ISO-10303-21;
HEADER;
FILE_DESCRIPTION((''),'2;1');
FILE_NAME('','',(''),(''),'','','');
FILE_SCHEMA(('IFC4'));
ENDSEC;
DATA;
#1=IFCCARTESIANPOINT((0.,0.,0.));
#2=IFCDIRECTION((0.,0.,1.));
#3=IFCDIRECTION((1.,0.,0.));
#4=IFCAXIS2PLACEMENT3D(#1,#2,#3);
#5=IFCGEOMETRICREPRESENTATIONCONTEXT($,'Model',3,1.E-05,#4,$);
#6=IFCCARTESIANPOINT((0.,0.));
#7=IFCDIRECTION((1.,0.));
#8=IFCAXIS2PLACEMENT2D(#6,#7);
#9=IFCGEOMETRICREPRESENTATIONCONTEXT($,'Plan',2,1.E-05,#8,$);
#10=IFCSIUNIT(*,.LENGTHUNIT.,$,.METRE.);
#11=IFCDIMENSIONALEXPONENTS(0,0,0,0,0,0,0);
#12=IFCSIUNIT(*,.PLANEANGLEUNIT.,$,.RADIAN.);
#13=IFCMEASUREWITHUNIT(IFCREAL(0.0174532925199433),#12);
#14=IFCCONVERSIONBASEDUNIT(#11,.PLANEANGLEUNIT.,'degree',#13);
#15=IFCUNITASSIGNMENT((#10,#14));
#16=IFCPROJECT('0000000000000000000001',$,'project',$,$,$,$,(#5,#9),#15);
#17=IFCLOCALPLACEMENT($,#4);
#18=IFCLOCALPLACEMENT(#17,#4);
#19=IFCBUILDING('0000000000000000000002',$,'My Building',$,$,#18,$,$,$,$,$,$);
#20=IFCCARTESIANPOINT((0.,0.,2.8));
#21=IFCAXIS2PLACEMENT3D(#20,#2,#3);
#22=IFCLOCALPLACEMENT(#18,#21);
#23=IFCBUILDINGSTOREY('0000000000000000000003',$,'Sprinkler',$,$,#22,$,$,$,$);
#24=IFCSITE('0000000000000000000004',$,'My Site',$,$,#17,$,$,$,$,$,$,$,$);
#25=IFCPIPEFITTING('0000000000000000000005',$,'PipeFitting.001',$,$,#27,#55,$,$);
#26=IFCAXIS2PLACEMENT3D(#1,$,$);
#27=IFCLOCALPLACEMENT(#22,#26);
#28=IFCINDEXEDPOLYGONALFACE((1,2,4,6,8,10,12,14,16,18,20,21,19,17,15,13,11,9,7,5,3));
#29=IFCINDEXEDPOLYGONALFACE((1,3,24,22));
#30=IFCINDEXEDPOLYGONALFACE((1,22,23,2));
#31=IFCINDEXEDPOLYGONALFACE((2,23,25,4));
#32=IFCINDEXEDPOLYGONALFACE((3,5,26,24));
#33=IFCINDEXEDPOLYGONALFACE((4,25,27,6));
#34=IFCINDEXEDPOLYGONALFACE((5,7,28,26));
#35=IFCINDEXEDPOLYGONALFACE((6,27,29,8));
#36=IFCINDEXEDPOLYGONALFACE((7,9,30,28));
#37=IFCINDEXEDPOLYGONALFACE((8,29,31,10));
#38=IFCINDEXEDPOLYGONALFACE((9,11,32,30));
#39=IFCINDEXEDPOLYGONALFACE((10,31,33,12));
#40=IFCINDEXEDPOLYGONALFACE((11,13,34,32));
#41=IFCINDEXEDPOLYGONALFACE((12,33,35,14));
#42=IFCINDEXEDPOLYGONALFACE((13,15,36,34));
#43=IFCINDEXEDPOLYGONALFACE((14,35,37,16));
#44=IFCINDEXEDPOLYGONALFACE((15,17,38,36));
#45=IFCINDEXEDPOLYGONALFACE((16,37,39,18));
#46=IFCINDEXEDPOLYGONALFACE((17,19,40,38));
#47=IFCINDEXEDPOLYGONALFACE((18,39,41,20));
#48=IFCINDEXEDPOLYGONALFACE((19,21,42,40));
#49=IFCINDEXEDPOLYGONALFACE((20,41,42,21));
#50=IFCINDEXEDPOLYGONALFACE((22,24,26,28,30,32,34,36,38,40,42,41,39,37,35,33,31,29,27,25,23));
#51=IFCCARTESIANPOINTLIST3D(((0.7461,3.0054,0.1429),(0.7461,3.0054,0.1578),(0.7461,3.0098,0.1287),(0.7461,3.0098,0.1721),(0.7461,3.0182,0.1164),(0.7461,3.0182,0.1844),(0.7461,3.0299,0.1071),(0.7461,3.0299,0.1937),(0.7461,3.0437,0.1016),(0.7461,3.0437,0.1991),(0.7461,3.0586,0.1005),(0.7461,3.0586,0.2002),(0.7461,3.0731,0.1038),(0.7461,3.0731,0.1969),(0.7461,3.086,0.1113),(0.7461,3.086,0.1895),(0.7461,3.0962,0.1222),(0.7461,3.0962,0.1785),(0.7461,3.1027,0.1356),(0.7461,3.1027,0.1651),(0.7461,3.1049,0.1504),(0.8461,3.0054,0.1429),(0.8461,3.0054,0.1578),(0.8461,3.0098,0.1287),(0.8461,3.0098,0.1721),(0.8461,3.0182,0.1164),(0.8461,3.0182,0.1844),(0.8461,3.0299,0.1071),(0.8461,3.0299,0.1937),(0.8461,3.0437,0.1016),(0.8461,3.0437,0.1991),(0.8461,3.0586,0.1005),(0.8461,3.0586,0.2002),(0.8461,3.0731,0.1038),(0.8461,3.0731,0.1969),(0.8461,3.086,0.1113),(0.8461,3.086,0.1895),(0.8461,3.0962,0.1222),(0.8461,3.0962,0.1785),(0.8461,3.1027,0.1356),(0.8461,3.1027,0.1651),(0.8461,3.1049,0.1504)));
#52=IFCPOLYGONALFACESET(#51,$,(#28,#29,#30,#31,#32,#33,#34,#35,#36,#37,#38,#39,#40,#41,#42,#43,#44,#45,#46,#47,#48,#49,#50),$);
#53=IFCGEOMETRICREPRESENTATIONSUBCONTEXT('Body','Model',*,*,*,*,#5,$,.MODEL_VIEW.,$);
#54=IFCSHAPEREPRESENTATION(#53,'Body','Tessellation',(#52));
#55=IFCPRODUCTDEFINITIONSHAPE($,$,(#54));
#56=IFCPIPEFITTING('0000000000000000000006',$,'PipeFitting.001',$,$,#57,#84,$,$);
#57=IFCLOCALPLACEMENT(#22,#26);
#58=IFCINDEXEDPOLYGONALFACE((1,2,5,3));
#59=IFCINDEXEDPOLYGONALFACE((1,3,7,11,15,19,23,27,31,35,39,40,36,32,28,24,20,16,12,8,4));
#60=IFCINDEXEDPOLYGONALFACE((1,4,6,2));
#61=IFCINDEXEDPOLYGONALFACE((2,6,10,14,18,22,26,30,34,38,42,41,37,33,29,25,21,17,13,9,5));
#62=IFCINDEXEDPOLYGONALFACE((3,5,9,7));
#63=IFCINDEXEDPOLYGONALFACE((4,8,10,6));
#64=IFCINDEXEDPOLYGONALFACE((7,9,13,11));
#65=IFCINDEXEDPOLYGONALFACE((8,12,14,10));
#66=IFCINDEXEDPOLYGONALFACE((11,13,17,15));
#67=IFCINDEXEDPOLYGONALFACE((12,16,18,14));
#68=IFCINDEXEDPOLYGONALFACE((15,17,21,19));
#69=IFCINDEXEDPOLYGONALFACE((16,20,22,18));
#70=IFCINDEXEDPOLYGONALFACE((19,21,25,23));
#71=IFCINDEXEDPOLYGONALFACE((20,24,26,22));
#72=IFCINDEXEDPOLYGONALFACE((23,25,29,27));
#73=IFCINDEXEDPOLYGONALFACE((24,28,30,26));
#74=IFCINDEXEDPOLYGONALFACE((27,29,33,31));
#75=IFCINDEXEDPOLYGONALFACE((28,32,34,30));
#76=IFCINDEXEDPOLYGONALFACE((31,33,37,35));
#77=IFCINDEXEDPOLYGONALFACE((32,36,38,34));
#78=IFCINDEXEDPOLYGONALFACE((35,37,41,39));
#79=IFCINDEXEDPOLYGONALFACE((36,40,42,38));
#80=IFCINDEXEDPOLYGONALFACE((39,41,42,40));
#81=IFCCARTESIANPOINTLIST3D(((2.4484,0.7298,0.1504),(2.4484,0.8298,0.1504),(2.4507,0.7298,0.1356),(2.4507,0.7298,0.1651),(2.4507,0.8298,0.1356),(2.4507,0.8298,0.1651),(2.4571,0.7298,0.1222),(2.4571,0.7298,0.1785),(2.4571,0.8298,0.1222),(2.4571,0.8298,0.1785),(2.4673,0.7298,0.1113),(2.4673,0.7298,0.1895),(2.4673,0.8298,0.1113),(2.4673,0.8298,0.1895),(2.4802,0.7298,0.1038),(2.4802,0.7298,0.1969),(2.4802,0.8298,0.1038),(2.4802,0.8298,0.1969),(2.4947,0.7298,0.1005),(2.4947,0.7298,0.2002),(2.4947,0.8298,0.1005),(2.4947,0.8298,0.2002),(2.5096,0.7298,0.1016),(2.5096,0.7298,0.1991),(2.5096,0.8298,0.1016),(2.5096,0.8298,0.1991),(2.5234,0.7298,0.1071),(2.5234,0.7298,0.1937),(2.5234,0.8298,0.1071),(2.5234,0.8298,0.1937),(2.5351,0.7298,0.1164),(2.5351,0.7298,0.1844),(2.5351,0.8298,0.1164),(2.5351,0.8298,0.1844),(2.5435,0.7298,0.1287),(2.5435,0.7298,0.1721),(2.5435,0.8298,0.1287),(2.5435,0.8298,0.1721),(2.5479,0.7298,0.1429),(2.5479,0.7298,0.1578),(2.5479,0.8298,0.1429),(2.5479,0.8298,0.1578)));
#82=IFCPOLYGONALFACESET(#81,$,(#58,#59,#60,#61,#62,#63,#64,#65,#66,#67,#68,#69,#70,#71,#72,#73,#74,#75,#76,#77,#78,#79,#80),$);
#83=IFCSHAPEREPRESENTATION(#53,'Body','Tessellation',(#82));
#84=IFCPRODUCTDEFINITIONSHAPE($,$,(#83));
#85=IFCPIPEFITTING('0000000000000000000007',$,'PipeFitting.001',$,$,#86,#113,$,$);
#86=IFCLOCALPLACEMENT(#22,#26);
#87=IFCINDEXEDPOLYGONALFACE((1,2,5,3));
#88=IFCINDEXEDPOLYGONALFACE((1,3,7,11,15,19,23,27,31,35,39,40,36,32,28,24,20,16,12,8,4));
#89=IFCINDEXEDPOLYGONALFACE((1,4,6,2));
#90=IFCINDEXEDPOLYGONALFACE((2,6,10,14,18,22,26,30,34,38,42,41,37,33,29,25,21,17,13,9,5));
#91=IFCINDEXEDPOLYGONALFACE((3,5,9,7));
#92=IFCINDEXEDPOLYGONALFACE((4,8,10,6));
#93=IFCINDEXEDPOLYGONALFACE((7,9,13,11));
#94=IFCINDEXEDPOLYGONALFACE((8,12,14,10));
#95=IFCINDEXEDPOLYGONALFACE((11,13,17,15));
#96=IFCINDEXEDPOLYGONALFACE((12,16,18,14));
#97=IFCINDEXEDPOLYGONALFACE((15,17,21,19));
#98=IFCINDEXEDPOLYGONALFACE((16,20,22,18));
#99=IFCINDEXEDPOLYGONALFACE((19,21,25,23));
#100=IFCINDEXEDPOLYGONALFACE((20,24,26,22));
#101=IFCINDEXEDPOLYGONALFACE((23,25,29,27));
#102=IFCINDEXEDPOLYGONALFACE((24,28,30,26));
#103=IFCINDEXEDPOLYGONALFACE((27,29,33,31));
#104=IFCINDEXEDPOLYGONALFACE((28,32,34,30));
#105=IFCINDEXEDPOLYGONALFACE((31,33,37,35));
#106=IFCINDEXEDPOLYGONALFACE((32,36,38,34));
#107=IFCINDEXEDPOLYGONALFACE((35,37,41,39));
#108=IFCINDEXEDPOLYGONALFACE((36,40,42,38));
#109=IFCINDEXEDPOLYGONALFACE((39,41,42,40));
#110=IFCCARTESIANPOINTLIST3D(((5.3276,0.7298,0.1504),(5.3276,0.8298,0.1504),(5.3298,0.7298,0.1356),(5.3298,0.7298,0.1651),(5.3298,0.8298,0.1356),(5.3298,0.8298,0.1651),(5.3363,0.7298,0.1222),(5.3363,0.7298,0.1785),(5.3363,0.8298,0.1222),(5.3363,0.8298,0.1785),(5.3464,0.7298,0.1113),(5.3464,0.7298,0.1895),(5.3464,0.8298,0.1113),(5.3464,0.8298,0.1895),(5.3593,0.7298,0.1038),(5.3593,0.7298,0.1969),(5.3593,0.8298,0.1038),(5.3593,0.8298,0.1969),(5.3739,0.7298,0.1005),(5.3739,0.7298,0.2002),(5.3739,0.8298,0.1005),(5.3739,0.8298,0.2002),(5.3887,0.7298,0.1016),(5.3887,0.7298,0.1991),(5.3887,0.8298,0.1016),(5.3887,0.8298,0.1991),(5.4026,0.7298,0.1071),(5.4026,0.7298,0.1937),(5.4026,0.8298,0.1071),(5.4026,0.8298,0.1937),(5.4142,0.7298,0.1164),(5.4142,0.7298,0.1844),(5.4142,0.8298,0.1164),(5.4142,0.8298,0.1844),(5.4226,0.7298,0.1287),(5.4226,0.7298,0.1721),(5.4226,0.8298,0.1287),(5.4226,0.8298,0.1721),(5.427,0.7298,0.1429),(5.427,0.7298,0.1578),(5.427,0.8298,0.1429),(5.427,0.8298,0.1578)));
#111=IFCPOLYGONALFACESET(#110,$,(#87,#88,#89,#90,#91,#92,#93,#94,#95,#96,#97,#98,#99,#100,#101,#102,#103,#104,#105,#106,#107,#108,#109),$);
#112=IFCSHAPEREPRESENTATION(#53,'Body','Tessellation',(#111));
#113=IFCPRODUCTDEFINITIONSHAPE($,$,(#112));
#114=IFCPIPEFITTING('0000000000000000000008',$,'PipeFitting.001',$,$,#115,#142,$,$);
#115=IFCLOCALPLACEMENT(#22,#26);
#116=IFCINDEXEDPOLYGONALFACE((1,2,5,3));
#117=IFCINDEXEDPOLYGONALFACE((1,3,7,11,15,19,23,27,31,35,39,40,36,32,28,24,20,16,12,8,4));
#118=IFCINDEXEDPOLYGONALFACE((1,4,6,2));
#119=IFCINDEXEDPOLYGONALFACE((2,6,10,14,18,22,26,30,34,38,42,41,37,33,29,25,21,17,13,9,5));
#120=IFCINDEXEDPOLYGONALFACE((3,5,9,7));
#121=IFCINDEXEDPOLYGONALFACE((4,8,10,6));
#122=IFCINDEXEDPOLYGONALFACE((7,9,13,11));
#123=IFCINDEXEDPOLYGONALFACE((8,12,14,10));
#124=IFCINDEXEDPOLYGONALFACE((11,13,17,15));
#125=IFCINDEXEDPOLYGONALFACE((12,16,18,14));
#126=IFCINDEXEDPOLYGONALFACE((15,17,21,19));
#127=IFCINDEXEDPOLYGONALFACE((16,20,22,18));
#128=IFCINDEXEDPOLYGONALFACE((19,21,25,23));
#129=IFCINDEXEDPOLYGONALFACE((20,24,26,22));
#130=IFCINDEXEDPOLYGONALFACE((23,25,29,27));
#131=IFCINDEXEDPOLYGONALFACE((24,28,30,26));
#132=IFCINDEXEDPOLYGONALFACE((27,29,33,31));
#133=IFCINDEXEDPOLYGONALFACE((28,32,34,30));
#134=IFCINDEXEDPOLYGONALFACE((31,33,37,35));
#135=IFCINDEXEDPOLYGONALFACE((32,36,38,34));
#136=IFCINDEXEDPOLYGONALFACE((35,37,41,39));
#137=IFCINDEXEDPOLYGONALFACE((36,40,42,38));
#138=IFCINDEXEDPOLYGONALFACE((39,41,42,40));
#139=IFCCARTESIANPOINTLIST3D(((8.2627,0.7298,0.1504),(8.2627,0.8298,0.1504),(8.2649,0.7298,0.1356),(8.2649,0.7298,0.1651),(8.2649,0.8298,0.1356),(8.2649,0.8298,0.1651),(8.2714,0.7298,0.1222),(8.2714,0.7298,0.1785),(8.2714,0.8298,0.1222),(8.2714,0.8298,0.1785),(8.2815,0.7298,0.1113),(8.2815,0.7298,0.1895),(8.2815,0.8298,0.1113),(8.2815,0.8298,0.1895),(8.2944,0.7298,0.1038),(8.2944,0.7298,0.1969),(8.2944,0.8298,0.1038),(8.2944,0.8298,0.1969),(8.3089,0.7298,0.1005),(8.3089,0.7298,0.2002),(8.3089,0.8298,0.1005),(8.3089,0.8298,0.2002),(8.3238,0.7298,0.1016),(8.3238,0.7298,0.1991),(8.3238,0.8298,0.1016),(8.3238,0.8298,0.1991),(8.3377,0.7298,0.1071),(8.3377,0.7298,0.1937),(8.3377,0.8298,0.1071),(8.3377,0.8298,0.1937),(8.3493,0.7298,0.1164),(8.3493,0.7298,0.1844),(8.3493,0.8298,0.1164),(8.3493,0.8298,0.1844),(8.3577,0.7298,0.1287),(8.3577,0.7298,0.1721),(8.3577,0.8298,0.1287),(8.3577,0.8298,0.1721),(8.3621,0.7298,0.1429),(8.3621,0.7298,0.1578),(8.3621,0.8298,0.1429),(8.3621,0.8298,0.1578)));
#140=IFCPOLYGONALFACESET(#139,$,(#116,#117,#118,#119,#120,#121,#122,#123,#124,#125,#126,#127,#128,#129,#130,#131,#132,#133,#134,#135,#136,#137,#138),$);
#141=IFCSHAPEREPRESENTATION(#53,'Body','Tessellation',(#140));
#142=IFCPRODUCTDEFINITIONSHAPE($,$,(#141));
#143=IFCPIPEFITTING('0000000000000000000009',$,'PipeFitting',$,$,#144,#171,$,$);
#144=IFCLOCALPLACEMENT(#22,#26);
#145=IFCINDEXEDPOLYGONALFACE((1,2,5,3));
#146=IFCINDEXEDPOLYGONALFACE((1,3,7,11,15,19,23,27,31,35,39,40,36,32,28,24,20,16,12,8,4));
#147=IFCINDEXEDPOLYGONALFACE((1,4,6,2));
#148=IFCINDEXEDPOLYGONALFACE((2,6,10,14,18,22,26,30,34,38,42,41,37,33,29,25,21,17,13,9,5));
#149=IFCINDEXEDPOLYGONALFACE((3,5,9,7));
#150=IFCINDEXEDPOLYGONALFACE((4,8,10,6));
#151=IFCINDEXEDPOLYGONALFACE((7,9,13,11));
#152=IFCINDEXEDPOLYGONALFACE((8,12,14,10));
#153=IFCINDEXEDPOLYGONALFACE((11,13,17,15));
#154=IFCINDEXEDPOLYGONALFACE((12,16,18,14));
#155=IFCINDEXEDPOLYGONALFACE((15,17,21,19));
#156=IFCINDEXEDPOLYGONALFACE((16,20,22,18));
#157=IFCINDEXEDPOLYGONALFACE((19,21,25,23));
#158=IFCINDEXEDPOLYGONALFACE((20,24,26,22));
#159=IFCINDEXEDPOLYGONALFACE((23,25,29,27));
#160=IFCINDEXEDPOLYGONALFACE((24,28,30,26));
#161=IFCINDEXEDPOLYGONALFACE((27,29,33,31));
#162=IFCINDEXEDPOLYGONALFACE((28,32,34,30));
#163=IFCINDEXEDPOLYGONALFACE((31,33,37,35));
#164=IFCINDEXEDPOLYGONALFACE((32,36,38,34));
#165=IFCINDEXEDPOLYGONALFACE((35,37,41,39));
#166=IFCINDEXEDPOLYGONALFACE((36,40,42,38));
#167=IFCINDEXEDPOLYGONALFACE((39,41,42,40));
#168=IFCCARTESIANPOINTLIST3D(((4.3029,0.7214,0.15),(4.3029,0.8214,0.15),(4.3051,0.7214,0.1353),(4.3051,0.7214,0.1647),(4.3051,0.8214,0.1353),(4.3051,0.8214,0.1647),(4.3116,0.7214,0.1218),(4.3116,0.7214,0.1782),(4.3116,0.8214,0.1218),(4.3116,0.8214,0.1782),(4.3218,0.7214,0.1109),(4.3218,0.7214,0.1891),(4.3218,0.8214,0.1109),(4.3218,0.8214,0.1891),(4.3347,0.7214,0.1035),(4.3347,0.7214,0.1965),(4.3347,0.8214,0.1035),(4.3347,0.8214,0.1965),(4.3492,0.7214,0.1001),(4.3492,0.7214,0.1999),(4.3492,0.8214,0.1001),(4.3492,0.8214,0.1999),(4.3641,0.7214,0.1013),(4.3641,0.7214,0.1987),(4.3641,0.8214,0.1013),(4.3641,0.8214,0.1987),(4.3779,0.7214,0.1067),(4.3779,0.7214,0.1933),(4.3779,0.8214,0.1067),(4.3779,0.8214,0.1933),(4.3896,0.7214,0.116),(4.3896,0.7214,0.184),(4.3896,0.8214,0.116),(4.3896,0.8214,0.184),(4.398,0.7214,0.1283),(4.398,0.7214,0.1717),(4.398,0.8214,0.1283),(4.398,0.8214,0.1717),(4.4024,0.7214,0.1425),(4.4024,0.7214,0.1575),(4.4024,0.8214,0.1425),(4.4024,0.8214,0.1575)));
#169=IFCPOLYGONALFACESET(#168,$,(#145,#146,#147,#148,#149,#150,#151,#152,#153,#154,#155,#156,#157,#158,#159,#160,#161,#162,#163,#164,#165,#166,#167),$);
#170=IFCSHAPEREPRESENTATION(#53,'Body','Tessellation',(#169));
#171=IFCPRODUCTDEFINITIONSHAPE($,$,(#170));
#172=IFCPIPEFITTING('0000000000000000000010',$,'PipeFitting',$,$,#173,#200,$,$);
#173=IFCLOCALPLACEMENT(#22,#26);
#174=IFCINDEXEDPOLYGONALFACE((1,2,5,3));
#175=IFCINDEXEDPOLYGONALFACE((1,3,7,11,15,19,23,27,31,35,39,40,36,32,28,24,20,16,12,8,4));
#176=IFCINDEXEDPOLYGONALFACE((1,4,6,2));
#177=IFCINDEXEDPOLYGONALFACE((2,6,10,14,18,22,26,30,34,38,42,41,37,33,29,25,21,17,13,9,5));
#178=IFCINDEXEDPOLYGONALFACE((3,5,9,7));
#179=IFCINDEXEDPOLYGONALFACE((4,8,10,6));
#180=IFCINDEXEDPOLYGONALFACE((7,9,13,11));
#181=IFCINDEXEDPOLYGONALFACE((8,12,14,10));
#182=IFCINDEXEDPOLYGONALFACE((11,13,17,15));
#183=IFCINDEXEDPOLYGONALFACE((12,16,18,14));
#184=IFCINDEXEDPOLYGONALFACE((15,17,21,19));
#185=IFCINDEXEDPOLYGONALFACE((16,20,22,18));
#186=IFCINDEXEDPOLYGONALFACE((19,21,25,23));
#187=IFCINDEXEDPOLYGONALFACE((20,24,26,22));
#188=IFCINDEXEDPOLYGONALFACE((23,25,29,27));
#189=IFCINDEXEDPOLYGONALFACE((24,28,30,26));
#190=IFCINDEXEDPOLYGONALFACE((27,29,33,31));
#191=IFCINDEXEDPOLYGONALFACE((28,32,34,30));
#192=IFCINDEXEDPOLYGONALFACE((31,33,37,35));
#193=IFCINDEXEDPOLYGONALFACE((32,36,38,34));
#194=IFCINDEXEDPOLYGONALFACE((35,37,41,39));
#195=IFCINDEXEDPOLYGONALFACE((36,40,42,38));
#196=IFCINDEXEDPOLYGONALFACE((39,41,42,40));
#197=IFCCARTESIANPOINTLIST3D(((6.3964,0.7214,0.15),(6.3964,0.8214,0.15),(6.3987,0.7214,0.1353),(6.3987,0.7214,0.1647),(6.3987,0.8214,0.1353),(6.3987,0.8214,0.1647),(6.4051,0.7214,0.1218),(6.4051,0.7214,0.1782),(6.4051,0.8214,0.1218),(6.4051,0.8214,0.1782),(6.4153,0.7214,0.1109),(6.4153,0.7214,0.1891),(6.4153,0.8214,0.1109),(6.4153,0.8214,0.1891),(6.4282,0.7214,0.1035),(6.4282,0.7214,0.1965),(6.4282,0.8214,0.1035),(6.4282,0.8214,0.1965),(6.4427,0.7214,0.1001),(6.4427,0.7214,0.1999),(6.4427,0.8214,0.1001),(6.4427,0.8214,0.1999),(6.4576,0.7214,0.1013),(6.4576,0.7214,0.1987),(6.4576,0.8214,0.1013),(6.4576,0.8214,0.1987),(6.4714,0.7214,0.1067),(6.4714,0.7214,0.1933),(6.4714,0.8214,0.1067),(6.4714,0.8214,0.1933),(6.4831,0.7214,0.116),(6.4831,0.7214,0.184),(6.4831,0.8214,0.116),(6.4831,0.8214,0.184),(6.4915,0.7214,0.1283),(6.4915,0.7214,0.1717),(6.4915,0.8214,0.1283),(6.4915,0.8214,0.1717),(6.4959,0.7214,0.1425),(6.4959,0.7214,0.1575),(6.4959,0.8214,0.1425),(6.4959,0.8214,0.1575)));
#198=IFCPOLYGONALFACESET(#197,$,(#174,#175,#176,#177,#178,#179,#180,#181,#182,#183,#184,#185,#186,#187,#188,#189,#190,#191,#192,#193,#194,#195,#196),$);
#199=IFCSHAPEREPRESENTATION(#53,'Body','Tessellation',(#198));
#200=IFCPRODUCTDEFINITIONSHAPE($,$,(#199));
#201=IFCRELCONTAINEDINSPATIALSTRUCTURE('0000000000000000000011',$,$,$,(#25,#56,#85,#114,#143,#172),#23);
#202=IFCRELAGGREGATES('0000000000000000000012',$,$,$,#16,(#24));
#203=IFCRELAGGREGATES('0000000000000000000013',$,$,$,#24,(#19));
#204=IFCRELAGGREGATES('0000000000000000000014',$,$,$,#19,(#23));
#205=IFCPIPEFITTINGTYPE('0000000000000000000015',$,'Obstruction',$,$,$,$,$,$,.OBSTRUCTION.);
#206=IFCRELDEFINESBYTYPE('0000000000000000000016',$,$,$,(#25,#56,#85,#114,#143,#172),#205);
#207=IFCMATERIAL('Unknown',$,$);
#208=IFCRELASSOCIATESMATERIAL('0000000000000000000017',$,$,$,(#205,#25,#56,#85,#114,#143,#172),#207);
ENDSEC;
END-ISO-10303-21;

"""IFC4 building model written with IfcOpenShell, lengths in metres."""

from ifc_helpers import new_model, entity, si_unit, converted_unit, frame, origin_with_axes, origin_2d_with_axis, place, context, subcontext, project, spatial, circle, extrude, material, material_profile, profile_set, profile_usage, type_object, element, save


model = new_model("IFC4")

# Units and contexts
model_context = context("Model", 3, precision=1e-05, world=origin_with_axes())
plan_context = context("Plan", 2, precision=1e-05, world=origin_2d_with_axis())
body_context = subcontext(model_context, "Body", "Model", "MODEL_VIEW")
ifc_project = project(units=[si_unit("LENGTHUNIT", "METRE"), converted_unit("PLANEANGLEUNIT", "degree", entity("IfcReal", 0.0174532925199433), si_unit("PLANEANGLEUNIT", "RADIAN"), dimensions=[0, 0, 0, 0, 0, 0, 0])], contexts=[model_context, plan_context])

# Site, building, storey
site_placement = place(None, origin_with_axes())
site = spatial("IfcSite", under=ifc_project, at=site_placement, Name="My Site")
building_placement = place(site_placement, origin_with_axes())
building = spatial("IfcBuilding", under=site, at=building_placement, Name="My Building")
storey_placement = place(building_placement, frame((0.0, 0.0, 2.8), z_axis=(0.0, 0.0, 1.0), x_axis=(1.0, 0.0, 0.0)))
storey = spatial("IfcBuildingStorey", under=building, at=storey_placement, Name="Sprinkler")

# Shared definitions
ifc_material = material(Name="Unknown")

# Pipe fittings
ifc_material_profile_1 = material_profile(ifc_material, circle(Radius=0.05))
ifc_profile_set_1 = profile_set([ifc_material_profile_1])
pipe_fitting_type_1 = type_object("IfcPipeFittingType", Name="Obstruction", PredefinedType="OBSTRUCTION", material=ifc_profile_set_1)
ifc_profile_usage_1 = profile_usage(ifc_profile_set_1, cardinal=8)
pipe_fitting_1_placement = place(storey_placement, frame((0.7461, 3.0549, 0.2004), z_axis=(1.0, 0.0, 0.0), x_axis=(0.0, 1.0, 0.0)))
element("IfcPipeFitting", 1, at=pipe_fitting_1_placement, inside=storey, type_object=pipe_fitting_type_1, material=ifc_profile_usage_1, Name="PipeFitting.001", context=body_context, shape_type="SweptSolid", body=[
    extrude(circle(Radius=0.05), frame((0.0, -0.05, 0.0), z_axis=(0.0, 0.0, 1.0), x_axis=(1.0, 0.0, 0.0)), (0.0, 0.0, 1.0), 0.1),
])
ifc_profile_usage_2 = profile_usage(ifc_profile_set_1, cardinal=8)
pipe_fitting_2_placement = place(storey_placement, frame((2.4984, 0.7298, 0.2004), z_axis=(0.0, 1.0, 0.0), x_axis=(-1.0, 0.0, 0.0)))
element("IfcPipeFitting", 2, at=pipe_fitting_2_placement, inside=storey, type_object=pipe_fitting_type_1, material=ifc_profile_usage_2, Name="PipeFitting.001", context=body_context, shape_type="SweptSolid", body=[
    extrude(circle(Radius=0.05), frame((0.0, -0.05, 0.0), z_axis=(0.0, 0.0, 1.0), x_axis=(1.0, 0.0, 0.0)), (0.0, 0.0, 1.0), 0.1),
])
ifc_profile_usage_3 = profile_usage(ifc_profile_set_1, cardinal=8)
pipe_fitting_3_placement = place(storey_placement, frame((5.3776, 0.7298, 0.2004), z_axis=(0.0, 1.0, 0.0), x_axis=(-1.0, 0.0, 0.0)))
element("IfcPipeFitting", 3, at=pipe_fitting_3_placement, inside=storey, type_object=pipe_fitting_type_1, material=ifc_profile_usage_3, Name="PipeFitting.001", context=body_context, shape_type="SweptSolid", body=[
    extrude(circle(Radius=0.05), frame((0.0, -0.05, 0.0), z_axis=(0.0, 0.0, 1.0), x_axis=(1.0, 0.0, 0.0)), (0.0, 0.0, 1.0), 0.1),
])
ifc_profile_usage_4 = profile_usage(ifc_profile_set_1, cardinal=8)
pipe_fitting_4_placement = place(storey_placement, frame((8.3127, 0.7298, 0.2004), z_axis=(0.0, 1.0, 0.0), x_axis=(-1.0, 0.0, 0.0)))
element("IfcPipeFitting", 4, at=pipe_fitting_4_placement, inside=storey, type_object=pipe_fitting_type_1, material=ifc_profile_usage_4, Name="PipeFitting.001", context=body_context, shape_type="SweptSolid", body=[
    extrude(circle(Radius=0.05), frame((0.0, -0.05, 0.0), z_axis=(0.0, 0.0, 1.0), x_axis=(1.0, 0.0, 0.0)), (0.0, 0.0, 1.0), 0.1),
])
ifc_profile_usage_5 = profile_usage(ifc_profile_set_1, cardinal=8)
pipe_fitting_5_placement = place(storey_placement, frame((4.3529, 0.7214, 0.2), z_axis=(0.0, 1.0, 0.0), x_axis=(-1.0, 0.0, 0.0)))
element("IfcPipeFitting", 5, at=pipe_fitting_5_placement, inside=storey, type_object=pipe_fitting_type_1, material=ifc_profile_usage_5, Name="PipeFitting", context=body_context, shape_type="SweptSolid", body=[
    extrude(circle(Radius=0.05), frame((0.0, -0.05, 0.0), z_axis=(0.0, 0.0, 1.0), x_axis=(1.0, 0.0, 0.0)), (0.0, 0.0, 1.0), 0.1),
])
ifc_profile_usage_6 = profile_usage(ifc_profile_set_1, cardinal=8)
pipe_fitting_6_placement = place(storey_placement, frame((6.4464, 0.7214, 0.2), z_axis=(0.0, 1.0, 0.0), x_axis=(-1.0, 0.0, 0.0)))
element("IfcPipeFitting", 6, at=pipe_fitting_6_placement, inside=storey, type_object=pipe_fitting_type_1, material=ifc_profile_usage_6, Name="PipeFitting", context=body_context, shape_type="SweptSolid", body=[
    extrude(circle(Radius=0.05), frame((0.0, -0.05, 0.0), z_axis=(0.0, 0.0, 1.0), x_axis=(1.0, 0.0, 0.0)), (0.0, 0.0, 1.0), 0.1),
])

save(model, "model.ifc")
